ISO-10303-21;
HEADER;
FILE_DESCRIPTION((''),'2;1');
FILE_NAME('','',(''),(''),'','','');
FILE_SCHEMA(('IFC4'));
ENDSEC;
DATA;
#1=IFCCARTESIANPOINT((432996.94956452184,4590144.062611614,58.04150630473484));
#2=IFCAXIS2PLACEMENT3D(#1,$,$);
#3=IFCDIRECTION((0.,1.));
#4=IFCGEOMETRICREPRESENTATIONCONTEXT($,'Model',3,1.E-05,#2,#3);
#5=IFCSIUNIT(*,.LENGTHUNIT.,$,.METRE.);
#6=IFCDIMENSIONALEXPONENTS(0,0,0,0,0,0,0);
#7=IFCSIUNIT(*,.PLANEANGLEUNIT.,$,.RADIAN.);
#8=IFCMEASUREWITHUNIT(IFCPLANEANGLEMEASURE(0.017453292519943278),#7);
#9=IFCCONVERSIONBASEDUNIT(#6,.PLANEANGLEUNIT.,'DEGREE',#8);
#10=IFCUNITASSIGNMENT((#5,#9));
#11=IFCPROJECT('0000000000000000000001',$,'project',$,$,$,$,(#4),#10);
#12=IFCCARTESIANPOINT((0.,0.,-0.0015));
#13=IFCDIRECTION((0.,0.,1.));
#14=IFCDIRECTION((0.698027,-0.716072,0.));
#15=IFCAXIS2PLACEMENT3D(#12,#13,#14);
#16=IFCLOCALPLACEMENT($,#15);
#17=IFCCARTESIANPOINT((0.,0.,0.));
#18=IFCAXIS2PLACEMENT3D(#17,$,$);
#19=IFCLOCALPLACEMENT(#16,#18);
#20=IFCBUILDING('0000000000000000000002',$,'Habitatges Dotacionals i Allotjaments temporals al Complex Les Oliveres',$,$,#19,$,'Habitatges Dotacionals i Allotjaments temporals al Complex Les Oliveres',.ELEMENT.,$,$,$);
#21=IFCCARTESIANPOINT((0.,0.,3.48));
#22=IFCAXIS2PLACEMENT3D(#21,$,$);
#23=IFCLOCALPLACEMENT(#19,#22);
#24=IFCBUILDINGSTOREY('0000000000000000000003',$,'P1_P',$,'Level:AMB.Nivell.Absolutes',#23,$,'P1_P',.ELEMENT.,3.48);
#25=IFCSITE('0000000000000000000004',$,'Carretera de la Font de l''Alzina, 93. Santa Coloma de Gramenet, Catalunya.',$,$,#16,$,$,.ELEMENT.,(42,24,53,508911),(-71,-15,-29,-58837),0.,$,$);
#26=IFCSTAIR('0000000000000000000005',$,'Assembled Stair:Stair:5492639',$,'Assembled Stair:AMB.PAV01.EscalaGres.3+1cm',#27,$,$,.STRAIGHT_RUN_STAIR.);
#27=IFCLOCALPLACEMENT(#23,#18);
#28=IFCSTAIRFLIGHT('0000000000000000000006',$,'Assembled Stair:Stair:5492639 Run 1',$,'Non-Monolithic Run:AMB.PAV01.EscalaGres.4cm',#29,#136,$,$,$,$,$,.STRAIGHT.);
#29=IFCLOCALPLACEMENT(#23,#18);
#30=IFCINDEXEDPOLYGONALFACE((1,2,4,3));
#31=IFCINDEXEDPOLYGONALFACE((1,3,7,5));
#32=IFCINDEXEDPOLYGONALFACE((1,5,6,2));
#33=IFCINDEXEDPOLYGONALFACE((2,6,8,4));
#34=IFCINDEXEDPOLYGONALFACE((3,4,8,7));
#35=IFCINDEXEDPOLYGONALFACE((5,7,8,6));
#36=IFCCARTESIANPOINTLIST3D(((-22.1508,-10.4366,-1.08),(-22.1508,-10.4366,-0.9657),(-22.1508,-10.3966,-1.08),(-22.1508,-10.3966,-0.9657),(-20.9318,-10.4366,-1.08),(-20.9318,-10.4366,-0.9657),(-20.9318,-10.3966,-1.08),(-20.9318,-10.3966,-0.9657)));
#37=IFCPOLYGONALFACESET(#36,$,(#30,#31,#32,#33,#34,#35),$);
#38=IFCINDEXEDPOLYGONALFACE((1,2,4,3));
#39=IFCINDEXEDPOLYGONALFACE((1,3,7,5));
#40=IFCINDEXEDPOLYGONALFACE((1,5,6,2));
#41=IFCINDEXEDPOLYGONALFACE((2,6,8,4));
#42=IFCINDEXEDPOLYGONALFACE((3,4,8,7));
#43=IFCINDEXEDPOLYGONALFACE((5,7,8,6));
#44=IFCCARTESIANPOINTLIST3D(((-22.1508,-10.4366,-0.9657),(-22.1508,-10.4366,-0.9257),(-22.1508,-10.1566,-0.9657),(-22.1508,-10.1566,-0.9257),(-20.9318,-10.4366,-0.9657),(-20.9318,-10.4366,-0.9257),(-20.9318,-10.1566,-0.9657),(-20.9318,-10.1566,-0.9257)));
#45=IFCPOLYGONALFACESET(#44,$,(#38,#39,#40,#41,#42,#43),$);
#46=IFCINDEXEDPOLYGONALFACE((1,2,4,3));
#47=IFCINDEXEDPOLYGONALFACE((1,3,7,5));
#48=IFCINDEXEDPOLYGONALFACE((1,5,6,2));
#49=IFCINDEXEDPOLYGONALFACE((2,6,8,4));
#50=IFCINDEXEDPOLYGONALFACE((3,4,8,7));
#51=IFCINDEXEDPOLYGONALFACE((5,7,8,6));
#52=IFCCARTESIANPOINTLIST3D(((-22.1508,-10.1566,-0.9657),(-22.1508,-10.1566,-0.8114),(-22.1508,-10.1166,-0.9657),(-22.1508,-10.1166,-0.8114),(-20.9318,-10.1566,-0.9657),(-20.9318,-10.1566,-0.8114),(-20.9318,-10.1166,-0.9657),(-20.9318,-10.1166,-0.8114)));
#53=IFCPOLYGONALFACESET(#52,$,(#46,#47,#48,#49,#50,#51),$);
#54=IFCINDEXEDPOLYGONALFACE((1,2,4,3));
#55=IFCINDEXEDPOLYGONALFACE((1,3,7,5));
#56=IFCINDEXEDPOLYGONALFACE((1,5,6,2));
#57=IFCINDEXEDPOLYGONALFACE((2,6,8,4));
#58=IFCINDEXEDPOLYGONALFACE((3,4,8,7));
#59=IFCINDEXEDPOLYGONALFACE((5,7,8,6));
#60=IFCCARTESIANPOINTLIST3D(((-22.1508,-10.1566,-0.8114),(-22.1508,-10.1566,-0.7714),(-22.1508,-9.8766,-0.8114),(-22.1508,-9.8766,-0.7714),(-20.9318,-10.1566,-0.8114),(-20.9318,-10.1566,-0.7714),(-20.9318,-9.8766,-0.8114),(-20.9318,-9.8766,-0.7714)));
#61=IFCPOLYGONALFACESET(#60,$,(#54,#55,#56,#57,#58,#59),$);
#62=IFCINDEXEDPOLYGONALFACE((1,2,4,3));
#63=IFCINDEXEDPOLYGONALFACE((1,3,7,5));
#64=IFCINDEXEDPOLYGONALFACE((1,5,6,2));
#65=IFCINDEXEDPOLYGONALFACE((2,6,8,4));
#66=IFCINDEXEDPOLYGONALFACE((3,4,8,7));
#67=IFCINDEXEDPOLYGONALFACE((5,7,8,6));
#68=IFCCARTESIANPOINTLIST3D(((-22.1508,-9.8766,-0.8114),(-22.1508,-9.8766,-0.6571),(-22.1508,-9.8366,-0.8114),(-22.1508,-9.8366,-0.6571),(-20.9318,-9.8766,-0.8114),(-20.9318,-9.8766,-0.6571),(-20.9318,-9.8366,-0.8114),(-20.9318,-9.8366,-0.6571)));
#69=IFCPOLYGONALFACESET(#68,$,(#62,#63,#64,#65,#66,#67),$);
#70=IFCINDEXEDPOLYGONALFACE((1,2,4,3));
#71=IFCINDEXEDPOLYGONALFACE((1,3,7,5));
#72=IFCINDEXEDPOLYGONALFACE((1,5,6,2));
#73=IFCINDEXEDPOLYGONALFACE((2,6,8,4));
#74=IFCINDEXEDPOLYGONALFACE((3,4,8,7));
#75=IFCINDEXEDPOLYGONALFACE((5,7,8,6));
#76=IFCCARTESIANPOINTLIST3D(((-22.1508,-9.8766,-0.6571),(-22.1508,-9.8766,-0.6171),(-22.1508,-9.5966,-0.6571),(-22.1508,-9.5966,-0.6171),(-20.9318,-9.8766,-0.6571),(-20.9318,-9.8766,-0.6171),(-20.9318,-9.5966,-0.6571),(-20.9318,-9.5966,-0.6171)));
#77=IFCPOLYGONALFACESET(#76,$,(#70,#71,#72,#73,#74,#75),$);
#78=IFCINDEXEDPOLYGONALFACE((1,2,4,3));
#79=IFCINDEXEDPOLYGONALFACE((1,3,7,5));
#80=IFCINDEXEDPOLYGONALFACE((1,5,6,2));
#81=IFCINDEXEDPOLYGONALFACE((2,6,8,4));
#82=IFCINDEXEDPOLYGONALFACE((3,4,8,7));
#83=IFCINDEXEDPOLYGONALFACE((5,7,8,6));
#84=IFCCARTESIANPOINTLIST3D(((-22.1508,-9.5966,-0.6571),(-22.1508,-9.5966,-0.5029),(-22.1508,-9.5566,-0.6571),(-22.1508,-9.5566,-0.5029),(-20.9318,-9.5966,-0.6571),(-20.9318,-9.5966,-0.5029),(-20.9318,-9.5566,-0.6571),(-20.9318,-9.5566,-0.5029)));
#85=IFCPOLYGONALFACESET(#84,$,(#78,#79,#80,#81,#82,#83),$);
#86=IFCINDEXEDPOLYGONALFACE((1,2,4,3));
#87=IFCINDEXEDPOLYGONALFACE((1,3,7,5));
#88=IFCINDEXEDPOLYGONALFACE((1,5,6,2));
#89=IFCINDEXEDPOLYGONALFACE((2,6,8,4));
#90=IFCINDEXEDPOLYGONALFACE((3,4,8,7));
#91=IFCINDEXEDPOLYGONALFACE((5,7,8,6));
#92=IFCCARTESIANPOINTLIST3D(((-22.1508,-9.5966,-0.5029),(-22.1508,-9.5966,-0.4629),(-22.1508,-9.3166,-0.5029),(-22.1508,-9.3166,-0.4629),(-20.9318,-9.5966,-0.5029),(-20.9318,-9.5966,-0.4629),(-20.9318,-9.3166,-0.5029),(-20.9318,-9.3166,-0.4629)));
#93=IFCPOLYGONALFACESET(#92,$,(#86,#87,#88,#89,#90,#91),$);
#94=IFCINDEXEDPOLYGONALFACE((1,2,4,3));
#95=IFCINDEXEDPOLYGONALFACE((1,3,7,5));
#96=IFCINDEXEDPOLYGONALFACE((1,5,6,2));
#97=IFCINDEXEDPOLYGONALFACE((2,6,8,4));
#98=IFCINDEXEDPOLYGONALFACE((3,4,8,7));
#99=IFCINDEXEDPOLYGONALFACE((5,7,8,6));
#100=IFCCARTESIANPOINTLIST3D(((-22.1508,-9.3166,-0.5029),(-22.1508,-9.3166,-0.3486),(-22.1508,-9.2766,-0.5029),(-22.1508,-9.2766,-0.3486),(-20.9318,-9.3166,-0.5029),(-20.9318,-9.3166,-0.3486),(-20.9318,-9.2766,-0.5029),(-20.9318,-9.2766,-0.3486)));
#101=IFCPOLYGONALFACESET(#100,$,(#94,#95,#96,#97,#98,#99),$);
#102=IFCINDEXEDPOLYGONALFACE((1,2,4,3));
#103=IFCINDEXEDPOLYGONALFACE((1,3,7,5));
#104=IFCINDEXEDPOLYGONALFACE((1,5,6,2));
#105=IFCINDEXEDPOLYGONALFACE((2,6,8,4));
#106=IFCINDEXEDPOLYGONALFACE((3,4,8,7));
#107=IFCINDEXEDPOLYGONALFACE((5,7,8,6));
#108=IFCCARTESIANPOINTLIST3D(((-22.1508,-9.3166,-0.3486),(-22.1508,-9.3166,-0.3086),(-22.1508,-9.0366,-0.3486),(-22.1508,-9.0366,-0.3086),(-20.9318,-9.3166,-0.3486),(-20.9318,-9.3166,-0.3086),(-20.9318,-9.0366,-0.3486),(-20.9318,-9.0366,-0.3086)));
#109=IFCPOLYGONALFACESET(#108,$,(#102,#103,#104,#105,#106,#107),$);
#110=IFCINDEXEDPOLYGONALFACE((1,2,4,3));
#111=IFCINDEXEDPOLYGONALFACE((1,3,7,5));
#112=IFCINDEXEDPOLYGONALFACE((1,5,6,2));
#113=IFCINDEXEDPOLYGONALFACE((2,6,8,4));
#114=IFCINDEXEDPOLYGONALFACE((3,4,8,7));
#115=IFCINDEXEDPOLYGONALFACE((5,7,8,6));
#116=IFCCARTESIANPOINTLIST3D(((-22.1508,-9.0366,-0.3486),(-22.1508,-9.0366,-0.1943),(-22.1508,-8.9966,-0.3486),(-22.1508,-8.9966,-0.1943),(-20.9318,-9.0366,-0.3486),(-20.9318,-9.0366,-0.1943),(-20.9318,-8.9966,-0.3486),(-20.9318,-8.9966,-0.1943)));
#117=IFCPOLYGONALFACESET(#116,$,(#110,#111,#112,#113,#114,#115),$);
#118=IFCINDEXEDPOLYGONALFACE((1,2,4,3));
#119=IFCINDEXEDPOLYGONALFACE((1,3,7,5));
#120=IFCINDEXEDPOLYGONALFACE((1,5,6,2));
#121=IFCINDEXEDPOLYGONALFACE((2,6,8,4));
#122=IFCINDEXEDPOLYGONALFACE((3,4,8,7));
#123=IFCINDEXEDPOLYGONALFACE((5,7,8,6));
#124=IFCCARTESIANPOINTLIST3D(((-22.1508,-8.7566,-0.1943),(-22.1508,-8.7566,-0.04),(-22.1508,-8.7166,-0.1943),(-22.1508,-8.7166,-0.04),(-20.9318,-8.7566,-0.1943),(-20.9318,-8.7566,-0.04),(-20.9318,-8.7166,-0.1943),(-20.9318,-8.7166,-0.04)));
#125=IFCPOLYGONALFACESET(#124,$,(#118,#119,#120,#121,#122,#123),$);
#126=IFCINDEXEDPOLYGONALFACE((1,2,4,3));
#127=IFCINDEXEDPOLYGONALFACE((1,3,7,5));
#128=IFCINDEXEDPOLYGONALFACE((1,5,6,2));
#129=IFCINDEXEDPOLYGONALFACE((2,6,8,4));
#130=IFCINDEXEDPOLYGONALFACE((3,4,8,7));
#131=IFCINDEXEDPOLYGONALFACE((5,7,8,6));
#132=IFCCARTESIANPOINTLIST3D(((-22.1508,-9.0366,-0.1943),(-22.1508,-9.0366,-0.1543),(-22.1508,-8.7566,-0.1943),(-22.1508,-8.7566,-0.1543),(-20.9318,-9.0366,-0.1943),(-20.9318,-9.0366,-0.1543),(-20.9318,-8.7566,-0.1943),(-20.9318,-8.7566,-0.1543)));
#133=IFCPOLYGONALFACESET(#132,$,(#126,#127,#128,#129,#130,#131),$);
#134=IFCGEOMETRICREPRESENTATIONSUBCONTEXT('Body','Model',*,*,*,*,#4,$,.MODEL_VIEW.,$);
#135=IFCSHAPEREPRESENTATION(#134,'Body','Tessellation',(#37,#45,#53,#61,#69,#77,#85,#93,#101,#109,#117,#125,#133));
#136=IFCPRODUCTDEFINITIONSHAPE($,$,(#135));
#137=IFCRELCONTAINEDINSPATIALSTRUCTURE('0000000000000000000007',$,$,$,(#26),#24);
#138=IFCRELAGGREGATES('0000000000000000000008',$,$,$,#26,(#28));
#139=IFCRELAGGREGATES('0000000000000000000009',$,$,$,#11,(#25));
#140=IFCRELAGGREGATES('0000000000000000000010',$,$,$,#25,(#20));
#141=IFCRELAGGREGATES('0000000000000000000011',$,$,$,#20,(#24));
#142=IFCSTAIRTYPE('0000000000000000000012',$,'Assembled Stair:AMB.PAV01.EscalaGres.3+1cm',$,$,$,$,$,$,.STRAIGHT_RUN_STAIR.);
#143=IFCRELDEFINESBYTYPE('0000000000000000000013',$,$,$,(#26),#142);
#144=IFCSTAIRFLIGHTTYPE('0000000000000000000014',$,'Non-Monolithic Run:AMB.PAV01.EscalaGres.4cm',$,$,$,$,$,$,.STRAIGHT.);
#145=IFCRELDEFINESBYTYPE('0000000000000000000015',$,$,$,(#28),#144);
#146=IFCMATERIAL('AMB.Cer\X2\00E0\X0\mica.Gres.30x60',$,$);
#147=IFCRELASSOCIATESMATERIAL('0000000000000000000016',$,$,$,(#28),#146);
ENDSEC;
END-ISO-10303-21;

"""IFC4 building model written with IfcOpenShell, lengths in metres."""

from ifc_helpers import new_model, entity, si_unit, converted_unit, direction, frame, origin, place, context, subcontext, project, spatial, indexed_curve, outline, extrude, material, type_object, element, aggregate, save


model = new_model("IFC4")

# Units and contexts
model_context = context("Model", 3, precision=1e-05, world=frame((432996.94956452184, 4590144.062611614, 58.04150630473484)), true_north=direction((0.0, 1.0)))
body_context = subcontext(model_context, "Body", "Model", "MODEL_VIEW")
ifc_project = project(units=[si_unit("LENGTHUNIT", "METRE"), converted_unit("PLANEANGLEUNIT", "DEGREE", entity("IfcPlaneAngleMeasure", 0.017453292519943278), si_unit("PLANEANGLEUNIT", "RADIAN"), dimensions=[0, 0, 0, 0, 0, 0, 0])], contexts=[model_context])

# Site, building, storey
site_placement = place(None, frame((0.0, 0.0, -0.0015), z_axis=(0.0, 0.0, 1.0), x_axis=(0.698027, -0.716072, 0.0)))
site = spatial("IfcSite", under=ifc_project, at=site_placement, Name="Carretera de la Font de l'Alzina, 93. Santa Coloma de Gramenet, Catalunya.", CompositionType="ELEMENT", RefLatitude=(42, 24, 53, 508911), RefLongitude=(-71, -15, -29, -58837), RefElevation=0.0)
building_placement = place(site_placement, origin())
building = spatial("IfcBuilding", under=site, at=building_placement, Name="Habitatges Dotacionals i Allotjaments temporals al Complex Les Oliveres", LongName="Habitatges Dotacionals i Allotjaments temporals al Complex Les Oliveres", CompositionType="ELEMENT")
storey_placement = place(building_placement, frame((0.0, 0.0, 3.48)))
storey = spatial("IfcBuildingStorey", under=building, at=storey_placement, Name="P1_P", ObjectType="Level:AMB.Nivell.Absolutes", LongName="P1_P", CompositionType="ELEMENT", Elevation=3.48)

# Shared definitions
ifc_material_1 = material(Name="AMB.Ceràmica.Gres.30x60")

# Stair, stair flight
stair_type_1 = type_object("IfcStairType", Name="Assembled Stair:AMB.PAV01.EscalaGres.3+1cm", PredefinedType="STRAIGHT_RUN_STAIR")
stair_1_placement = place(storey_placement, origin())
stair_1 = element("IfcStair", 1, at=stair_1_placement, inside=storey, type_object=stair_type_1, Name="Assembled Stair:Stair:5492639", ObjectType="Assembled Stair:AMB.PAV01.EscalaGres.3+1cm", PredefinedType="STRAIGHT_RUN_STAIR")
stair_flight_type = type_object("IfcStairFlightType", Name="Non-Monolithic Run:AMB.PAV01.EscalaGres.4cm", PredefinedType="STRAIGHT")
stair_flight_1_placement = place(stair_1_placement, origin())
stair_flight_1 = element("IfcStairFlight", 2, at=stair_flight_1_placement, type_object=stair_flight_type, material=ifc_material_1, Name="Assembled Stair:Stair:5492639 Run 1", ObjectType="Non-Monolithic Run:AMB.PAV01.EscalaGres.4cm", PredefinedType="STRAIGHT", context=body_context, shape_type="SweptSolid", body=[
    extrude(outline(indexed_curve([(-0.6095, -0.02), (0.6095, -0.02), (0.6095, 0.02), (-0.6095, 0.02), (-0.6095, -0.02)], self_intersect=False)), frame((-21.5413, -10.4166, -1.08), z_axis=(0.0, 0.0, 1.0), x_axis=(-1.0, 0.0, 0.0)), (0.0, 0.0, 1.0), 0.1143),
    extrude(outline(indexed_curve([(-0.14, -0.6095), (0.14, -0.6095), (0.14, 0.6095), (-0.14, 0.6095), (-0.14, -0.6095)], self_intersect=False)), frame((-21.5413, -10.2966, -0.9657), z_axis=(0.0, 0.0, 1.0), x_axis=(0.0, -1.0, 0.0)), (0.0, 0.0, 1.0), 0.04),
    extrude(outline(indexed_curve([(-0.6095, -0.02), (0.6095, -0.02), (0.6095, 0.02), (-0.6095, 0.02), (-0.6095, -0.02)], self_intersect=False)), frame((-21.5413, -10.1366, -0.9657), z_axis=(0.0, 0.0, 1.0), x_axis=(-1.0, 0.0, 0.0)), (0.0, 0.0, 1.0), 0.1543),
    extrude(outline(indexed_curve([(-0.14, -0.6095), (0.14, -0.6095), (0.14, 0.6095), (-0.14, 0.6095), (-0.14, -0.6095)], self_intersect=False)), frame((-21.5413, -10.0166, -0.8114), z_axis=(0.0, 0.0, 1.0), x_axis=(0.0, -1.0, 0.0)), (0.0, 0.0, 1.0), 0.04),
    extrude(outline(indexed_curve([(-0.6095, -0.02), (0.6095, -0.02), (0.6095, 0.02), (-0.6095, 0.02), (-0.6095, -0.02)], self_intersect=False)), frame((-21.5413, -9.8566, -0.8114), z_axis=(0.0, 0.0, 1.0), x_axis=(-1.0, 0.0, 0.0)), (0.0, 0.0, 1.0), 0.1543),
    extrude(outline(indexed_curve([(-0.14, -0.6095), (0.14, -0.6095), (0.14, 0.6095), (-0.14, 0.6095), (-0.14, -0.6095)], self_intersect=False)), frame((-21.5413, -9.7366, -0.6571), z_axis=(0.0, 0.0, 1.0), x_axis=(0.0, -1.0, 0.0)), (0.0, 0.0, 1.0), 0.04),
    extrude(outline(indexed_curve([(-0.6095, -0.02), (0.6095, -0.02), (0.6095, 0.02), (-0.6095, 0.02), (-0.6095, -0.02)], self_intersect=False)), frame((-21.5413, -9.5766, -0.6571), z_axis=(0.0, 0.0, 1.0), x_axis=(-1.0, 0.0, 0.0)), (0.0, 0.0, 1.0), 0.1543),
    extrude(outline(indexed_curve([(-0.14, -0.6095), (0.14, -0.6095), (0.14, 0.6095), (-0.14, 0.6095), (-0.14, -0.6095)], self_intersect=False)), frame((-21.5413, -9.4566, -0.5029), z_axis=(0.0, 0.0, 1.0), x_axis=(0.0, -1.0, 0.0)), (0.0, 0.0, 1.0), 0.04),
    extrude(outline(indexed_curve([(-0.6095, -0.02), (0.6095, -0.02), (0.6095, 0.02), (-0.6095, 0.02), (-0.6095, -0.02)], self_intersect=False)), frame((-21.5413, -9.2966, -0.5029), z_axis=(0.0, 0.0, 1.0), x_axis=(-1.0, 0.0, 0.0)), (0.0, 0.0, 1.0), 0.1543),
    extrude(outline(indexed_curve([(-0.14, -0.6095), (0.14, -0.6095), (0.14, 0.6095), (-0.14, 0.6095), (-0.14, -0.6095)], self_intersect=False)), frame((-21.5413, -9.1766, -0.3486), z_axis=(0.0, 0.0, 1.0), x_axis=(0.0, -1.0, 0.0)), (0.0, 0.0, 1.0), 0.04),
    extrude(outline(indexed_curve([(-0.6095, -0.02), (0.6095, -0.02), (0.6095, 0.02), (-0.6095, 0.02), (-0.6095, -0.02)], self_intersect=False)), frame((-21.5413, -9.0166, -0.3486), z_axis=(0.0, 0.0, 1.0), x_axis=(-1.0, 0.0, 0.0)), (0.0, 0.0, 1.0), 0.1543),
    extrude(outline(indexed_curve([(-0.6095, -0.02), (0.6095, -0.02), (0.6095, 0.02), (-0.6095, 0.02), (-0.6095, -0.02)], self_intersect=False)), frame((-21.5413, -8.7366, -0.1943), z_axis=(0.0, 0.0, 1.0), x_axis=(-1.0, 0.0, 0.0)), (0.0, 0.0, 1.0), 0.1543),
    extrude(outline(indexed_curve([(-0.14, -0.6095), (0.14, -0.6095), (0.14, 0.6095), (-0.14, 0.6095), (-0.14, -0.6095)], self_intersect=False)), frame((-21.5413, -8.8966, -0.1943), z_axis=(0.0, 0.0, 1.0), x_axis=(0.0, -1.0, 0.0)), (0.0, 0.0, 1.0), 0.04),
])
aggregate(stair_1, [stair_flight_1])

save(model, "model.ifc")
